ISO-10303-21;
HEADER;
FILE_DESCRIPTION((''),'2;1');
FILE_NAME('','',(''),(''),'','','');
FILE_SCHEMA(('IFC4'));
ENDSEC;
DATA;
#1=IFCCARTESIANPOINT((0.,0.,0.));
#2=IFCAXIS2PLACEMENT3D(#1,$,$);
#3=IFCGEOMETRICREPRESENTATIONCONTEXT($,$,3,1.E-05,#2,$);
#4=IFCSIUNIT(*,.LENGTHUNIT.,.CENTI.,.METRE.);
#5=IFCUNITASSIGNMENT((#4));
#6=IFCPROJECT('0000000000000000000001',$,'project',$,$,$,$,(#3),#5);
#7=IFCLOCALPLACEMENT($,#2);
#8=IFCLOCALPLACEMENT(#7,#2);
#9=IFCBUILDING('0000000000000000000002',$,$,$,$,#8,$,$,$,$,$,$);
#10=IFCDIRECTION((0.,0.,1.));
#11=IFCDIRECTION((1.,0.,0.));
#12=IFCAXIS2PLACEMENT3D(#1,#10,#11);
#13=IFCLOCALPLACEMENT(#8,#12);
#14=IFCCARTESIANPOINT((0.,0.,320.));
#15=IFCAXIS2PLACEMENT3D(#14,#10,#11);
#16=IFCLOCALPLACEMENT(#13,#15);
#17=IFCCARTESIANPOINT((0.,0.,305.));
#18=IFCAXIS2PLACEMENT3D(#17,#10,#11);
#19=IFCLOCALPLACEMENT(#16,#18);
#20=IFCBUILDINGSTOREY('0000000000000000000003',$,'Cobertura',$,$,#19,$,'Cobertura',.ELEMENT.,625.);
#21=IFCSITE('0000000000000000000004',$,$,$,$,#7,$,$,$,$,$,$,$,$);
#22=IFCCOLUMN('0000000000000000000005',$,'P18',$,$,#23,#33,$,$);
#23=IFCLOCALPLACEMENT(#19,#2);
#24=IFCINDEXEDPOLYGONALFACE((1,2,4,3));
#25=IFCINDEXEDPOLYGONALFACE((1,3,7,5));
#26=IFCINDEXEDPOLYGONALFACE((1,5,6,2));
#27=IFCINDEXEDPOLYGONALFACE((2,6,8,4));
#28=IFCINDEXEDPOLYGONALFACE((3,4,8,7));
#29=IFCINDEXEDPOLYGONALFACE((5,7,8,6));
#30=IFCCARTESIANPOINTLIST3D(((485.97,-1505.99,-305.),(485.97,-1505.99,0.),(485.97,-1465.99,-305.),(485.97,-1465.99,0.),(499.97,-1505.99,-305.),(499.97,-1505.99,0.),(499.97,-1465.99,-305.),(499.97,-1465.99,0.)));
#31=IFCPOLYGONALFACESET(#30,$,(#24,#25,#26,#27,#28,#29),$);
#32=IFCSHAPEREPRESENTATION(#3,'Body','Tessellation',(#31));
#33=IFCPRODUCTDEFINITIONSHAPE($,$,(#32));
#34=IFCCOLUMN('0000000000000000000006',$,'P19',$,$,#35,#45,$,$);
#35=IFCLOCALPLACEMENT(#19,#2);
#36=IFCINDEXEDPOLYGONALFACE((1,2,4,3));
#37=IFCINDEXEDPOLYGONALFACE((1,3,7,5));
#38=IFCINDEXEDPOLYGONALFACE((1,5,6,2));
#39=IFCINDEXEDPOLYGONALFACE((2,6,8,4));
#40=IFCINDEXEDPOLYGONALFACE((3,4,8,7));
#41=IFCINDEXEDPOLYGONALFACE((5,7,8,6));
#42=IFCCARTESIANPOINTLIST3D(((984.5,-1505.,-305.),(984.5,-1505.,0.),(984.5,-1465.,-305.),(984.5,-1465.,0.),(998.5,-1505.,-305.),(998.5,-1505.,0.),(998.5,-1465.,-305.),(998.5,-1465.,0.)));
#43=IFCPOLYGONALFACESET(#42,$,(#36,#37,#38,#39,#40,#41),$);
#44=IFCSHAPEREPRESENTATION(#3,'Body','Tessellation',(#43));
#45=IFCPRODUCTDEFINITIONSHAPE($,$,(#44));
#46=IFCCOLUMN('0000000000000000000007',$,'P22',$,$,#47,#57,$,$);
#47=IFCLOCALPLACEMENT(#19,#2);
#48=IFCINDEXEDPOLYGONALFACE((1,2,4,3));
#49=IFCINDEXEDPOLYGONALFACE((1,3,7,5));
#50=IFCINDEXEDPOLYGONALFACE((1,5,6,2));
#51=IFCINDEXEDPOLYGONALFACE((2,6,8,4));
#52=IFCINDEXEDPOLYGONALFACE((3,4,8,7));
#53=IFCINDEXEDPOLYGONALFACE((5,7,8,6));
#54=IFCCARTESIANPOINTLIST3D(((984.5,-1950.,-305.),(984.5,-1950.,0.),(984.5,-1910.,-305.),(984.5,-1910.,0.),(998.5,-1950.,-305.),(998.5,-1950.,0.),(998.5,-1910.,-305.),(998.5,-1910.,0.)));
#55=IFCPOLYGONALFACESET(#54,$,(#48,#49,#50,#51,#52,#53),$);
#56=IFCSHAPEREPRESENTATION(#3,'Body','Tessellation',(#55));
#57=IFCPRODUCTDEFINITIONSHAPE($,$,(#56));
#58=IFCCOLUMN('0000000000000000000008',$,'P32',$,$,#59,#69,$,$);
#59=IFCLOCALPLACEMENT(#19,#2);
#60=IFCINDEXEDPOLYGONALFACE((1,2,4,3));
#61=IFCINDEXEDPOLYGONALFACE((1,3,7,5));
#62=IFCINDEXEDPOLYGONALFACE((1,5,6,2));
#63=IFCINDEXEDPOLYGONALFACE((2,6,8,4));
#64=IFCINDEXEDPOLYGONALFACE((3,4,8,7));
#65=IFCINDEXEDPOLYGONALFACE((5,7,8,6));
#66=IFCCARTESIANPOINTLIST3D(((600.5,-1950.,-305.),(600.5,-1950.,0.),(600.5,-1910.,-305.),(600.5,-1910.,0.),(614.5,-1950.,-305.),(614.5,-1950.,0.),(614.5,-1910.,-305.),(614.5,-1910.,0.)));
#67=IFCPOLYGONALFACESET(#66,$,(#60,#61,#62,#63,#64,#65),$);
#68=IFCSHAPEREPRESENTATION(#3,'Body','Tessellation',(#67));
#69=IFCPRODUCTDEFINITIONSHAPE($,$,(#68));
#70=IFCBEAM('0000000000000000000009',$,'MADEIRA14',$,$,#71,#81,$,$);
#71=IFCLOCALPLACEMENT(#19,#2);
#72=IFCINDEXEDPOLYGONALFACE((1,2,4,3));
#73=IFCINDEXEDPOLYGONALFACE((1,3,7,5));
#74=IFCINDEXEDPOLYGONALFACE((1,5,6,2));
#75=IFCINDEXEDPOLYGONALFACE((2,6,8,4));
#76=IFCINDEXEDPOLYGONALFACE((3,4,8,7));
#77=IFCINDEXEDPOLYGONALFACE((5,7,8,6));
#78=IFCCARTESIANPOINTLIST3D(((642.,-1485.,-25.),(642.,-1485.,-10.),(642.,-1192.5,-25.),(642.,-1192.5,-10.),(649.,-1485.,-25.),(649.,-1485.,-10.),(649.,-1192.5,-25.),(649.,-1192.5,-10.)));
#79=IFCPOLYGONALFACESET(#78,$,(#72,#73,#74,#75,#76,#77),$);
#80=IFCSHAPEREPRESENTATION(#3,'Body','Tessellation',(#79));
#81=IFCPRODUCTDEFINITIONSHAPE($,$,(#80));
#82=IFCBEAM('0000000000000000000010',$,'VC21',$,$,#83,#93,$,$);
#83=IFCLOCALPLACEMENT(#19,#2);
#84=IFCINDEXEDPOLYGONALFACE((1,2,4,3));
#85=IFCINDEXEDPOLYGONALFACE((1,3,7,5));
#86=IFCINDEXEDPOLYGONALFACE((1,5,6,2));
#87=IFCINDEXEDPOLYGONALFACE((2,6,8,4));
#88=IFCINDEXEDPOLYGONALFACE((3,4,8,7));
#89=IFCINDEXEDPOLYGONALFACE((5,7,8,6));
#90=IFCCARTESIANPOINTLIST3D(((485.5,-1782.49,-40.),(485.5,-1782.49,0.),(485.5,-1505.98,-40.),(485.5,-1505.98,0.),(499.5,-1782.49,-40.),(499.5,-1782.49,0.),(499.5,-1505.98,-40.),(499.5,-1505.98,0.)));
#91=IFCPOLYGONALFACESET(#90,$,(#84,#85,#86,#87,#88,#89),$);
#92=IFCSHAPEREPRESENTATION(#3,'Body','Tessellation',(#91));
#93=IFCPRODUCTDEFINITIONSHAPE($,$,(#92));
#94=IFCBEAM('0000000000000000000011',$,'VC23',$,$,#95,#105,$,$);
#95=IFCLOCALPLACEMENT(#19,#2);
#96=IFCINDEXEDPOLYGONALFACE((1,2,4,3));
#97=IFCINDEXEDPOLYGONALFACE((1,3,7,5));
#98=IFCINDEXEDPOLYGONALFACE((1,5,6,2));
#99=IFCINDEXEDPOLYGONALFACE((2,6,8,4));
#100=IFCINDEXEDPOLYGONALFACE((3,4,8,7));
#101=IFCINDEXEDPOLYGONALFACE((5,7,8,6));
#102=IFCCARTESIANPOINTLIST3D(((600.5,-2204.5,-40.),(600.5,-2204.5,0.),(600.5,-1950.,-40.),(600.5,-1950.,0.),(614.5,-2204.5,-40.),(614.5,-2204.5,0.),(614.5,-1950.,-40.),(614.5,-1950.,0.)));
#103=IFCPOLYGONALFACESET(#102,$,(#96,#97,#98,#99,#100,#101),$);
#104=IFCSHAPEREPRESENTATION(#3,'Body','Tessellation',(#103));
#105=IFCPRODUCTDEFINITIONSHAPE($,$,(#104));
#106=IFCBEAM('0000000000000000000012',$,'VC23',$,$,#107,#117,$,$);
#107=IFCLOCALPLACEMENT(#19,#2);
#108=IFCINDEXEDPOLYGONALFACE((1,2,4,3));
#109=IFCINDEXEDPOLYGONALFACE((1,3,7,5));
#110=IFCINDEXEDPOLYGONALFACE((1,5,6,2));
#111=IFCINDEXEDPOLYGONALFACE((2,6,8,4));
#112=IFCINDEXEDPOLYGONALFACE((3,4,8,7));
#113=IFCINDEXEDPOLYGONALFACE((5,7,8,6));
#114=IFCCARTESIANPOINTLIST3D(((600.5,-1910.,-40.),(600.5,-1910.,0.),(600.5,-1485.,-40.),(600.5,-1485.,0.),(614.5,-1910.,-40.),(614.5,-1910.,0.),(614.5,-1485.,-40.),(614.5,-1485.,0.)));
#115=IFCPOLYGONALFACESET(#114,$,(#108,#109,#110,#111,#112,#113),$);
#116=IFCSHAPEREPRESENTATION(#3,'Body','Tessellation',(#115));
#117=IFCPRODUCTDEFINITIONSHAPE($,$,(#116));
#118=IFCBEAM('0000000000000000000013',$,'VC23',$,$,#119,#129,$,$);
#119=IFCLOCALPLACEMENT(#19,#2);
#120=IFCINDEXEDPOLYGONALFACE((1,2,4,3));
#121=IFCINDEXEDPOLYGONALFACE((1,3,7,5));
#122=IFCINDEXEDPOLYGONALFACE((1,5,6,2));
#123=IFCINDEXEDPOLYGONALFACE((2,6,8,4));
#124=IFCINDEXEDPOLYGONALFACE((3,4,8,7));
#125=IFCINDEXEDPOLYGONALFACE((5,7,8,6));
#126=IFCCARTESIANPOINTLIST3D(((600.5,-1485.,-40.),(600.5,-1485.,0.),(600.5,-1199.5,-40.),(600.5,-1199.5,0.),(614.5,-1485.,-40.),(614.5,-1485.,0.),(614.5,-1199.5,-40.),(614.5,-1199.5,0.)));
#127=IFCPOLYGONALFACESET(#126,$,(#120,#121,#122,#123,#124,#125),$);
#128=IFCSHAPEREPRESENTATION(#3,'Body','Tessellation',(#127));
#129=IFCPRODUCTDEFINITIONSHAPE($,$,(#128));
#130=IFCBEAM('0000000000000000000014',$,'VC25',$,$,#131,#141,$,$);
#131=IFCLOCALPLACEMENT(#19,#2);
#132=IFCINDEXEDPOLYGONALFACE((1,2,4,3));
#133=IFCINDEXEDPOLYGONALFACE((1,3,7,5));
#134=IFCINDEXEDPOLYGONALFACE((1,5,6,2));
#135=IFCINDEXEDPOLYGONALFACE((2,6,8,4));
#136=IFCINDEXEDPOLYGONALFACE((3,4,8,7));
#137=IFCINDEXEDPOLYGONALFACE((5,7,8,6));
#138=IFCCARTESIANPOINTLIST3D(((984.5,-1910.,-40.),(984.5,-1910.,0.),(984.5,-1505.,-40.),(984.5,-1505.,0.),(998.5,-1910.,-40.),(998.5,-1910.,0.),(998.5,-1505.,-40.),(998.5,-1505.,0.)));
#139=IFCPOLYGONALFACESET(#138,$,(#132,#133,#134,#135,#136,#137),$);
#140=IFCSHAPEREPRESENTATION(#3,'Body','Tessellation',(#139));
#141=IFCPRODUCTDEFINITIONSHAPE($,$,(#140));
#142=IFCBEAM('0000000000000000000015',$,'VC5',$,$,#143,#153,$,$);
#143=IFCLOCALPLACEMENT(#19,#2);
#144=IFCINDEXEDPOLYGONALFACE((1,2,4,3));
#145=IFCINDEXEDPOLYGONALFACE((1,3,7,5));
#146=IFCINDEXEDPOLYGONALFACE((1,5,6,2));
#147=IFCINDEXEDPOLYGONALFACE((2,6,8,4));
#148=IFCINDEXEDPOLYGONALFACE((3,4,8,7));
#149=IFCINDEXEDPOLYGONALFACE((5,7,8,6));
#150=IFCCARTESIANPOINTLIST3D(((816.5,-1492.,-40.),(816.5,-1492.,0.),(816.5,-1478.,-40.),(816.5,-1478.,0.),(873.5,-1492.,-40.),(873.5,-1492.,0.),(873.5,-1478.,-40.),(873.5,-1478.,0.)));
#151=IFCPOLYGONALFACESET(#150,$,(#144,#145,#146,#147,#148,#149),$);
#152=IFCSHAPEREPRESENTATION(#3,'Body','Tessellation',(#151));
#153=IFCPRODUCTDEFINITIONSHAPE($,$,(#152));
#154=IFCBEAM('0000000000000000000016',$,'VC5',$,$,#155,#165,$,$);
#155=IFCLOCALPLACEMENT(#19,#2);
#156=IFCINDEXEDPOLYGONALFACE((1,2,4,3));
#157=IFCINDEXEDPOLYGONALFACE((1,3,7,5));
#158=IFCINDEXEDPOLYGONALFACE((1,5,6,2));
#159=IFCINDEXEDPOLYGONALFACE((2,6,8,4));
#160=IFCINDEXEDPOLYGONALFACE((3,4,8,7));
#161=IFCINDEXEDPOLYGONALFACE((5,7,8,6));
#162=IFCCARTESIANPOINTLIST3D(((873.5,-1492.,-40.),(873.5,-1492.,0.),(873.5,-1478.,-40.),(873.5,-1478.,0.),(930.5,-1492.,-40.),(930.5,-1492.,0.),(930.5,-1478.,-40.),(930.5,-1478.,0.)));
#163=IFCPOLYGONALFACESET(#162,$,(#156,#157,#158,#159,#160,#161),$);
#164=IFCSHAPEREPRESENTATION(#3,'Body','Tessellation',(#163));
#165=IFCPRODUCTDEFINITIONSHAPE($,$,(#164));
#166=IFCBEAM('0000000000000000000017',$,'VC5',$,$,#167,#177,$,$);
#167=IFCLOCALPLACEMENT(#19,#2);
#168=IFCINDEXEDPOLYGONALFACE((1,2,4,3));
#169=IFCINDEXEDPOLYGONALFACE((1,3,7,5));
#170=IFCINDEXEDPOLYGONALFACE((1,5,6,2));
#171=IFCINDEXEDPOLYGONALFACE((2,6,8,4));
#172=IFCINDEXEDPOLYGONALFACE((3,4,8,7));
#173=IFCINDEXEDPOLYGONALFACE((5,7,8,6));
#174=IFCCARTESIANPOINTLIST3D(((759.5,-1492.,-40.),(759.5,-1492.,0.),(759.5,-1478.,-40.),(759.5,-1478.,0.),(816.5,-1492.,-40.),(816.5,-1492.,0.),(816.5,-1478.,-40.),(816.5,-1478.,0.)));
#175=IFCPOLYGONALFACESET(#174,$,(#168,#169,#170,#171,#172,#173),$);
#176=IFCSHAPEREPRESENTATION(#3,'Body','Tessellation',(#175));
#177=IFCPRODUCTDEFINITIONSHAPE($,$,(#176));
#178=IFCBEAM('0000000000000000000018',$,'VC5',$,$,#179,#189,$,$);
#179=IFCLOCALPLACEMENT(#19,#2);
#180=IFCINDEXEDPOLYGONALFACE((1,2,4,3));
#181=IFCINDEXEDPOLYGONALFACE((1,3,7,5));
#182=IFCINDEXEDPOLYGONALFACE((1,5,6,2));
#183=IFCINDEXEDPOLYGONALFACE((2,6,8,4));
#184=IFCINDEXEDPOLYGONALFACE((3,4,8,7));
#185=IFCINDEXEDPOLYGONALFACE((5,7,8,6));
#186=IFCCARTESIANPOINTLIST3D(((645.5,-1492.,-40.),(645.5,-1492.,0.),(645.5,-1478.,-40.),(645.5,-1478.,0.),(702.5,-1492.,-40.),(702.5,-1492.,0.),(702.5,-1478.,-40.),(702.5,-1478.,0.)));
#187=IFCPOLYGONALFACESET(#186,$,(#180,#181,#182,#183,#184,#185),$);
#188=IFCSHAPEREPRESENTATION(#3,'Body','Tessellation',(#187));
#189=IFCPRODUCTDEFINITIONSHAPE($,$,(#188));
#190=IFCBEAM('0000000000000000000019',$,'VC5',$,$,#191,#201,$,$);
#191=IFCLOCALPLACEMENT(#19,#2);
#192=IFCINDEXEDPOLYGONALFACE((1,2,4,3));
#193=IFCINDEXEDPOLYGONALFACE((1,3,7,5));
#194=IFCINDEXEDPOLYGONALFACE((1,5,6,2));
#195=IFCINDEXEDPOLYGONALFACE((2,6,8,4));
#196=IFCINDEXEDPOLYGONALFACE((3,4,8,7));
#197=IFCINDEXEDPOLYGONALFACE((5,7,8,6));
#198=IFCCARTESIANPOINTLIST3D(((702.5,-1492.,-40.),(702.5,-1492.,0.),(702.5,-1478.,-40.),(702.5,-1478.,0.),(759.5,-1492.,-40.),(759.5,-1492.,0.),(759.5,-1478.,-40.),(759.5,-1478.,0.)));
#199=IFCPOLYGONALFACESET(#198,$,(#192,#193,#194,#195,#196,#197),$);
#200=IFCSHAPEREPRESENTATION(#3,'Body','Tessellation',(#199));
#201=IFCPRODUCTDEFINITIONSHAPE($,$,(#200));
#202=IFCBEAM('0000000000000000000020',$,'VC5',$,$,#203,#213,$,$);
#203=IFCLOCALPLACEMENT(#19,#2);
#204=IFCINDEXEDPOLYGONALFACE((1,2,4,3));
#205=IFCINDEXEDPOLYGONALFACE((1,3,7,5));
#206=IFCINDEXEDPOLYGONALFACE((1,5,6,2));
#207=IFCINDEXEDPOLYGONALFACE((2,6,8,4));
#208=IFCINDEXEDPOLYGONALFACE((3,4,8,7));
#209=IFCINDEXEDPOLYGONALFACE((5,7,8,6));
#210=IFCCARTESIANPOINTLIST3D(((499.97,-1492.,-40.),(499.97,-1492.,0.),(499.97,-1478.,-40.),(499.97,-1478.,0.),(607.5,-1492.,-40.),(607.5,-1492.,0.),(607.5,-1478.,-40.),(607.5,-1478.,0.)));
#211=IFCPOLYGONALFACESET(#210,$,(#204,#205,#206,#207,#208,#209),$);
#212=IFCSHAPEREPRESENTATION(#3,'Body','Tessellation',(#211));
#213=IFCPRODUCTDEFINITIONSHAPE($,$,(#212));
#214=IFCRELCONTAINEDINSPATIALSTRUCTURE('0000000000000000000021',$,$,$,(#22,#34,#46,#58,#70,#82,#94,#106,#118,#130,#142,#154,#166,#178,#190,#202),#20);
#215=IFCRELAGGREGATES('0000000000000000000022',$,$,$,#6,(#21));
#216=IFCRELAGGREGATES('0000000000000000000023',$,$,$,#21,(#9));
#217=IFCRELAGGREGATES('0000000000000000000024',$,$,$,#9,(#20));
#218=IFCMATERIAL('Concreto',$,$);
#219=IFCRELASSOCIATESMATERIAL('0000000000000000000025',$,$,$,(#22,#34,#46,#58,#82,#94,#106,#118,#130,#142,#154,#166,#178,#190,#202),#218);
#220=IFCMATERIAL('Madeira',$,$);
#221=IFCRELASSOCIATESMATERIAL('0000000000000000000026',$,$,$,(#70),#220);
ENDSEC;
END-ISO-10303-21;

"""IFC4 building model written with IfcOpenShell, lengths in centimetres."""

from ifc_helpers import new_model, si_unit, frame, origin, origin_with_axes, place, context, project, spatial, polyline, outline, extrude, material, element, save


model = new_model("IFC4")

# Units and contexts
context_of_model = context(None, 3, precision=1e-05, world=origin())
ifc_project = project(units=[si_unit("LENGTHUNIT", "METRE", prefix="CENTI")], contexts=[context_of_model])

# Site, building, storey
site_placement = place(None, origin())
site = spatial("IfcSite", under=ifc_project, at=site_placement)
building_placement = place(site_placement, origin())
building = spatial("IfcBuilding", under=site, at=building_placement)
placement_1 = place(building_placement, origin_with_axes())
placement_2 = place(placement_1, frame((0.0, 0.0, 320.0), z_axis=(0.0, 0.0, 1.0), x_axis=(1.0, 0.0, 0.0)))
storey_placement = place(placement_2, frame((0.0, 0.0, 305.0), z_axis=(0.0, 0.0, 1.0), x_axis=(1.0, 0.0, 0.0)))
storey = spatial("IfcBuildingStorey", under=building, at=storey_placement, Name="Cobertura", LongName="Cobertura", CompositionType="ELEMENT", Elevation=625.0)

# Columns
ifc_material_1 = material(Name="Concreto")
column_1_placement = place(storey_placement, frame((492.97, -1485.99, 0.0), z_axis=(0.0, 0.0, 1.0), x_axis=(1.0, 0.0, 0.0)))
element("IfcColumn", 1, at=column_1_placement, inside=storey, material=ifc_material_1, Name="P18", context=context_of_model, shape_type="SolidModel", body=[
    extrude(outline(polyline([(-7.0, -20.0), (7.0, -20.0), (7.0, 20.0), (-7.0, 20.0), (-7.0, -20.0)])), origin_with_axes(), (0.0, 0.0, -1.0), 305.0),
])
for number, where, z_axis, x_axis, name in (
    (2, (991.5, -1485.0, 0.0), (0.0, 0.0, 1.0), (1.0, 0.0, 0.0), "P19"),
    (3, (991.5, -1930.0, 0.0), (0.0, 0.0, 1.0), (1.0, 0.0, 0.0), "P22"),
):
    element("IfcColumn", number, at=place(storey_placement, frame(where, z_axis=z_axis, x_axis=x_axis)), inside=storey, material=ifc_material_1, Name=name, context=context_of_model, shape_type="SolidModel", body=[
        extrude(outline(polyline([(7.0, 20.0), (-7.0, 20.0), (-7.0, -20.0), (7.0, -20.0), (7.0, 20.0)])), origin_with_axes(), (0.0, 0.0, -1.0), 305.0),
    ])
column_2_placement = place(storey_placement, frame((607.5, -1930.0, 0.0), z_axis=(0.0, 0.0, 1.0), x_axis=(1.0, 0.0, 0.0)))
element("IfcColumn", 4, at=column_2_placement, inside=storey, material=ifc_material_1, Name="P32", context=context_of_model, shape_type="SolidModel", body=[
    extrude(outline(polyline([(-7.0, -20.0), (7.0, -20.0), (7.0, 20.0), (-7.0, 20.0), (-7.0, -20.0)])), origin_with_axes(), (0.0, 0.0, -1.0), 305.0),
])

# Beams
ifc_material_2 = material(Name="Madeira")
beam_1_placement = place(storey_placement, frame((645.5, -1338.75, -10.0), z_axis=(0.0, 0.0, 1.0), x_axis=(1.0, 0.0, 0.0)))
element("IfcBeam", 5, at=beam_1_placement, inside=storey, material=ifc_material_2, Name="MADEIRA14", context=context_of_model, shape_type="SolidModel", body=[
    extrude(outline(polyline([(-3.5, -7.5), (-3.5, 7.5), (3.5, 7.5), (3.5, -7.5), (-3.5, -7.5)])), frame((0.0, -146.25, -7.5), z_axis=(0.0, 1.0, 0.0), x_axis=(1.0, 0.0, 0.0)), (0.0, 0.0, 1.0), 292.5),
])
beam_2_placement = place(storey_placement, frame((492.5, -1644.24, 0.0), z_axis=(0.0, 0.0, 1.0), x_axis=(1.0, 0.0, 0.0)))
element("IfcBeam", 6, at=beam_2_placement, inside=storey, material=ifc_material_1, Name="VC21", context=context_of_model, shape_type="SolidModel", body=[
    extrude(outline(polyline([(-7.0, -20.0), (7.0, -20.0), (7.0, 20.0), (-7.0, 20.0), (-7.0, -20.0)])), frame((0.0, -138.25, -20.0), z_axis=(0.0, 1.0, 0.0), x_axis=(1.0, 0.0, 0.0)), (0.0, 0.0, 1.0), 276.51),
])
beam_3_placement = place(storey_placement, frame((607.5, -2077.25, 0.0), z_axis=(0.0, 0.0, 1.0), x_axis=(1.0, 0.0, 0.0)))
element("IfcBeam", 7, at=beam_3_placement, inside=storey, material=ifc_material_1, Name="VC23", context=context_of_model, shape_type="SolidModel", body=[
    extrude(outline(polyline([(-7.0, -20.0), (7.0, -20.0), (7.0, 20.0), (-7.0, 20.0), (-7.0, -20.0)])), frame((0.0, -127.25, -20.0), z_axis=(0.0, 1.0, 0.0), x_axis=(1.0, 0.0, 0.0)), (0.0, 0.0, 1.0), 254.5),
])
beam_4_placement = place(storey_placement, frame((607.5, -1697.5, 0.0), z_axis=(0.0, 0.0, 1.0), x_axis=(1.0, 0.0, 0.0)))
element("IfcBeam", 8, at=beam_4_placement, inside=storey, material=ifc_material_1, Name="VC23", context=context_of_model, shape_type="SolidModel", body=[
    extrude(outline(polyline([(-7.0, -20.0), (7.0, -20.0), (7.0, 20.0), (-7.0, 20.0), (-7.0, -20.0)])), frame((0.0, -212.5, -20.0), z_axis=(0.0, 1.0, 0.0), x_axis=(1.0, 0.0, 0.0)), (0.0, 0.0, 1.0), 425.0),
])
beam_5_placement = place(storey_placement, frame((607.5, -1342.25, 0.0), z_axis=(0.0, 0.0, 1.0), x_axis=(1.0, 0.0, 0.0)))
element("IfcBeam", 9, at=beam_5_placement, inside=storey, material=ifc_material_1, Name="VC23", context=context_of_model, shape_type="SolidModel", body=[
    extrude(outline(polyline([(-7.0, -20.0), (7.0, -20.0), (7.0, 20.0), (-7.0, 20.0), (-7.0, -20.0)])), frame((0.0, -142.75, -20.0), z_axis=(0.0, 1.0, 0.0), x_axis=(1.0, 0.0, 0.0)), (0.0, 0.0, 1.0), 285.5),
])
beam_6_placement = place(storey_placement, frame((991.5, -1707.5, 0.0), z_axis=(0.0, 0.0, 1.0), x_axis=(1.0, 0.0, 0.0)))
element("IfcBeam", 10, at=beam_6_placement, inside=storey, material=ifc_material_1, Name="VC25", context=context_of_model, shape_type="SolidModel", body=[
    extrude(outline(polyline([(-7.0, -20.0), (7.0, -20.0), (7.0, 20.0), (-7.0, 20.0), (-7.0, -20.0)])), frame((0.0, -202.5, -20.0), z_axis=(0.0, 1.0, 0.0), x_axis=(1.0, 0.0, 0.0)), (0.0, 0.0, 1.0), 405.0),
])
for number, where, z_axis, x_axis, name in (
    (11, (845.0, -1485.0, 0.0), (0.0, 0.0, 1.0), (1.0, 0.0, 0.0), "VC5"),
    (12, (902.0, -1485.0, 0.0), (0.0, 0.0, 1.0), (1.0, 0.0, 0.0), "VC5"),
    (13, (788.0, -1485.0, 0.0), (0.0, 0.0, 1.0), (1.0, 0.0, 0.0), "VC5"),
    (14, (674.0, -1485.0, 0.0), (0.0, 0.0, 1.0), (1.0, 0.0, 0.0), "VC5"),
    (15, (731.0, -1485.0, 0.0), (0.0, 0.0, 1.0), (1.0, 0.0, 0.0), "VC5"),
):
    element("IfcBeam", number, at=place(storey_placement, frame(where, z_axis=z_axis, x_axis=x_axis)), inside=storey, material=ifc_material_1, Name=name, context=context_of_model, shape_type="SolidModel", body=[
        extrude(outline(polyline([(-7.0, -20.0), (7.0, -20.0), (7.0, 20.0), (-7.0, 20.0), (-7.0, -20.0)])), frame((-28.5, 0.0, -20.0), z_axis=(1.0, 0.0, 0.0), x_axis=(0.0, -1.0, 0.0)), (0.0, 0.0, 1.0), 57.0),
    ])
beam_7_placement = place(storey_placement, frame((553.74, -1485.0, 0.0), z_axis=(0.0, 0.0, 1.0), x_axis=(1.0, 0.0, 0.0)))
element("IfcBeam", 16, at=beam_7_placement, inside=storey, material=ifc_material_1, Name="VC5", context=context_of_model, shape_type="SolidModel", body=[
    extrude(outline(polyline([(-7.0, -20.0), (7.0, -20.0), (7.0, 20.0), (-7.0, 20.0), (-7.0, -20.0)])), frame((-53.77, 0.0, -20.0), z_axis=(1.0, 0.0, 0.0), x_axis=(0.0, -1.0, 0.0)), (0.0, 0.0, 1.0), 107.53),
])

save(model, "model.ifc")
